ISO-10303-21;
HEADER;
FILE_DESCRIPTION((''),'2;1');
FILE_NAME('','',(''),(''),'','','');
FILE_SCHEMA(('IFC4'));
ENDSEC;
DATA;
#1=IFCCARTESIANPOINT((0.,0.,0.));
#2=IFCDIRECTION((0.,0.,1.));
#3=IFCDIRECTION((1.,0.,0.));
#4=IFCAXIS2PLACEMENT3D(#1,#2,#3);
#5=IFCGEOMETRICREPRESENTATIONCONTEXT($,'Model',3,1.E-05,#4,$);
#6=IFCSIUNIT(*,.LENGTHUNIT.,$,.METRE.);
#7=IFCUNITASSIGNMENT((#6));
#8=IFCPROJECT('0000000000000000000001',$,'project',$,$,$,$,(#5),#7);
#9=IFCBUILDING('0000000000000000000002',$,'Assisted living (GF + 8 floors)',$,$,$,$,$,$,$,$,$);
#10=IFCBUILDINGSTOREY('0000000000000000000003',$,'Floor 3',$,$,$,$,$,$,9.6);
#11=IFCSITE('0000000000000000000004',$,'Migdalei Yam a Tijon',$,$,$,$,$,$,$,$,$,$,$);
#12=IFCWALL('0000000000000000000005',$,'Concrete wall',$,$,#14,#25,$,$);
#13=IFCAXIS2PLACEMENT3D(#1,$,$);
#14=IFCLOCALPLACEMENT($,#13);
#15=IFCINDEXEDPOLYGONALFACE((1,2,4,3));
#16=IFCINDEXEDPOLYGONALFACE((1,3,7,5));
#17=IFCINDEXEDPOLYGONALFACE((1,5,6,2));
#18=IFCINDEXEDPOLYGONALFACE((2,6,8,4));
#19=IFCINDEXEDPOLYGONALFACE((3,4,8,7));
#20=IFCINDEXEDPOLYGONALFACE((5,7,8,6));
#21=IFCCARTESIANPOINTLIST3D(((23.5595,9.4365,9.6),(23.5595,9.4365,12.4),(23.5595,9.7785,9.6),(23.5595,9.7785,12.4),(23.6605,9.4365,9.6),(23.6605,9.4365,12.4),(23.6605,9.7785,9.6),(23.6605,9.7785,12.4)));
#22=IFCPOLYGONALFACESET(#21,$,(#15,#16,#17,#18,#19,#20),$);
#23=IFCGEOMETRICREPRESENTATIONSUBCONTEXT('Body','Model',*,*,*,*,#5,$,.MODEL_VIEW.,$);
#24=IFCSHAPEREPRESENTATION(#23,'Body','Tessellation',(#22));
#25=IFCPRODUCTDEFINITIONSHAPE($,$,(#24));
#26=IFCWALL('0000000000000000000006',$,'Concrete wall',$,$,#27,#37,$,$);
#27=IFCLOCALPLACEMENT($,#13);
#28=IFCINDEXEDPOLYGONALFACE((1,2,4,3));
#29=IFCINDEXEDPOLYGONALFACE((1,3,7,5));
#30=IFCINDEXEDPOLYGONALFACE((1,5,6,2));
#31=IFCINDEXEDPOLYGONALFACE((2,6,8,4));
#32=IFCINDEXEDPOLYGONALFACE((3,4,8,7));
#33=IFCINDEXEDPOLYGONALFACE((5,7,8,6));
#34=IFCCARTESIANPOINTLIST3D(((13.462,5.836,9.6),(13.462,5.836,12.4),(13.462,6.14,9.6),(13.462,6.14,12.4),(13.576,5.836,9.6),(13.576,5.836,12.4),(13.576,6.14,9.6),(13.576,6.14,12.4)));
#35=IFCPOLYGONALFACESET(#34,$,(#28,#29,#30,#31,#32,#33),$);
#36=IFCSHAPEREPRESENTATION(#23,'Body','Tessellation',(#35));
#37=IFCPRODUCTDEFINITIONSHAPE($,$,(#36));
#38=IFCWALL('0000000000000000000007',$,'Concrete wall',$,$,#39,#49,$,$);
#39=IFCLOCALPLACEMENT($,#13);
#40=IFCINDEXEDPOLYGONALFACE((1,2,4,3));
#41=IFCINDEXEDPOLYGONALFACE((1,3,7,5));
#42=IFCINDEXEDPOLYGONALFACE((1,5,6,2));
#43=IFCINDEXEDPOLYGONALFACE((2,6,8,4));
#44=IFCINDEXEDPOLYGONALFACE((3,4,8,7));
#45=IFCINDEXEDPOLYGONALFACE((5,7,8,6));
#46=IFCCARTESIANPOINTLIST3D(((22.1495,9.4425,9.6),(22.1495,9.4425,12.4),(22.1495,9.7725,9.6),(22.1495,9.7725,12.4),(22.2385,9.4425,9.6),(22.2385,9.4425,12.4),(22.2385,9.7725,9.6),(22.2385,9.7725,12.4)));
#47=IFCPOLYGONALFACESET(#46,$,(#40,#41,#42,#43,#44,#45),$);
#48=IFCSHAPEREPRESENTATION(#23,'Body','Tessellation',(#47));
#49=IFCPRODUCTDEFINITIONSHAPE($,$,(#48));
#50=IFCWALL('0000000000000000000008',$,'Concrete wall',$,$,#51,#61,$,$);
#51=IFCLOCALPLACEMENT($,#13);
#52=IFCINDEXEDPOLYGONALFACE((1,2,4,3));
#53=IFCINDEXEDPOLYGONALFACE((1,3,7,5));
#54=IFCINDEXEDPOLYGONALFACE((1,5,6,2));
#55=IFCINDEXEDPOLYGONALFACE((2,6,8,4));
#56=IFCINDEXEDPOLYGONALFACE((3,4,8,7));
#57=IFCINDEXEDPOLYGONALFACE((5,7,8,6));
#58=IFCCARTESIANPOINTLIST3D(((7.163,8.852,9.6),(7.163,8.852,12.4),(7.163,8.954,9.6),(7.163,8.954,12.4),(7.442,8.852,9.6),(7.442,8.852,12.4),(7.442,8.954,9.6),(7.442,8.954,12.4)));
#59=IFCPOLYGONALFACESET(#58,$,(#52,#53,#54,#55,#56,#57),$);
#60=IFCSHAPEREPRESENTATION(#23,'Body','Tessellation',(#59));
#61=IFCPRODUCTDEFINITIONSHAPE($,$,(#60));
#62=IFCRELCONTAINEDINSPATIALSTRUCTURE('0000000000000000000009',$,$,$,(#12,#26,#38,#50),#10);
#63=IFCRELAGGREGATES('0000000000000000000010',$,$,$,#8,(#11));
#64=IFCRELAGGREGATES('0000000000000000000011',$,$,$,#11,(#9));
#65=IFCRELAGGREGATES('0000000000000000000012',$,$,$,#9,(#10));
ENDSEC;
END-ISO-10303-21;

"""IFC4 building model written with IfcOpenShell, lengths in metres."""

from ifc_helpers import new_model, si_unit, frame, origin_with_axes, context, subcontext, project, spatial, line, indexed_curve, outline, extrude, element, save


model = new_model("IFC4")

# Units and contexts
model_context = context("Model", 3, precision=1e-05, world=origin_with_axes())
body_context = subcontext(model_context, "Body", "Model", "MODEL_VIEW")
ifc_project = project(units=[si_unit("LENGTHUNIT", "METRE")], contexts=[model_context])

# Site, building, storey
site = spatial("IfcSite", under=ifc_project, Name="Migdalei Yam a Tijon")
building = spatial("IfcBuilding", under=site, Name="Assisted living (GF + 8 floors)")
storey = spatial("IfcBuildingStorey", under=building, Name="Floor 3", Elevation=9.6)

# Walls
element("IfcWall", 1, inside=storey, Name="Concrete wall", context=body_context, shape_type="SweptSolid", body=[
    extrude(outline(indexed_curve([(0.0, 0.0), (0.101, 0.0), (0.101, 0.342), (0.0, 0.342)], segments=[line(1, 2, 3, 4, 1)])), frame((23.5595, 9.4365, 9.6), z_axis=(0.0, 0.0, 1.0), x_axis=(1.0, 0.0, 0.0)), (0.0, 0.0, 1.0), 2.8),
])
element("IfcWall", 2, inside=storey, Name="Concrete wall", context=body_context, shape_type="SweptSolid", body=[
    extrude(outline(indexed_curve([(0.0, 0.0), (0.114, 0.0), (0.114, 0.304), (0.0, 0.304)], segments=[line(1, 2, 3, 4, 1)])), frame((13.462, 5.836, 9.6), z_axis=(0.0, 0.0, 1.0), x_axis=(1.0, 0.0, 0.0)), (0.0, 0.0, 1.0), 2.8),
])
element("IfcWall", 3, inside=storey, Name="Concrete wall", context=body_context, shape_type="SweptSolid", body=[
    extrude(outline(indexed_curve([(0.0, 0.0), (0.089, 0.0), (0.089, 0.33), (0.0, 0.33)], segments=[line(1, 2, 3, 4, 1)])), frame((22.1495, 9.4425, 9.6), z_axis=(0.0, 0.0, 1.0), x_axis=(1.0, 0.0, 0.0)), (0.0, 0.0, 1.0), 2.8),
])
element("IfcWall", 4, inside=storey, Name="Concrete wall", context=body_context, shape_type="SweptSolid", body=[
    extrude(outline(indexed_curve([(0.0, 0.0), (0.279, 0.0), (0.279, 0.102), (0.0, 0.102)], segments=[line(1, 2, 3, 4, 1)])), frame((7.163, 8.852, 9.6), z_axis=(0.0, 0.0, 1.0), x_axis=(1.0, 0.0, 0.0)), (0.0, 0.0, 1.0), 2.8),
])

save(model, "model.ifc")
